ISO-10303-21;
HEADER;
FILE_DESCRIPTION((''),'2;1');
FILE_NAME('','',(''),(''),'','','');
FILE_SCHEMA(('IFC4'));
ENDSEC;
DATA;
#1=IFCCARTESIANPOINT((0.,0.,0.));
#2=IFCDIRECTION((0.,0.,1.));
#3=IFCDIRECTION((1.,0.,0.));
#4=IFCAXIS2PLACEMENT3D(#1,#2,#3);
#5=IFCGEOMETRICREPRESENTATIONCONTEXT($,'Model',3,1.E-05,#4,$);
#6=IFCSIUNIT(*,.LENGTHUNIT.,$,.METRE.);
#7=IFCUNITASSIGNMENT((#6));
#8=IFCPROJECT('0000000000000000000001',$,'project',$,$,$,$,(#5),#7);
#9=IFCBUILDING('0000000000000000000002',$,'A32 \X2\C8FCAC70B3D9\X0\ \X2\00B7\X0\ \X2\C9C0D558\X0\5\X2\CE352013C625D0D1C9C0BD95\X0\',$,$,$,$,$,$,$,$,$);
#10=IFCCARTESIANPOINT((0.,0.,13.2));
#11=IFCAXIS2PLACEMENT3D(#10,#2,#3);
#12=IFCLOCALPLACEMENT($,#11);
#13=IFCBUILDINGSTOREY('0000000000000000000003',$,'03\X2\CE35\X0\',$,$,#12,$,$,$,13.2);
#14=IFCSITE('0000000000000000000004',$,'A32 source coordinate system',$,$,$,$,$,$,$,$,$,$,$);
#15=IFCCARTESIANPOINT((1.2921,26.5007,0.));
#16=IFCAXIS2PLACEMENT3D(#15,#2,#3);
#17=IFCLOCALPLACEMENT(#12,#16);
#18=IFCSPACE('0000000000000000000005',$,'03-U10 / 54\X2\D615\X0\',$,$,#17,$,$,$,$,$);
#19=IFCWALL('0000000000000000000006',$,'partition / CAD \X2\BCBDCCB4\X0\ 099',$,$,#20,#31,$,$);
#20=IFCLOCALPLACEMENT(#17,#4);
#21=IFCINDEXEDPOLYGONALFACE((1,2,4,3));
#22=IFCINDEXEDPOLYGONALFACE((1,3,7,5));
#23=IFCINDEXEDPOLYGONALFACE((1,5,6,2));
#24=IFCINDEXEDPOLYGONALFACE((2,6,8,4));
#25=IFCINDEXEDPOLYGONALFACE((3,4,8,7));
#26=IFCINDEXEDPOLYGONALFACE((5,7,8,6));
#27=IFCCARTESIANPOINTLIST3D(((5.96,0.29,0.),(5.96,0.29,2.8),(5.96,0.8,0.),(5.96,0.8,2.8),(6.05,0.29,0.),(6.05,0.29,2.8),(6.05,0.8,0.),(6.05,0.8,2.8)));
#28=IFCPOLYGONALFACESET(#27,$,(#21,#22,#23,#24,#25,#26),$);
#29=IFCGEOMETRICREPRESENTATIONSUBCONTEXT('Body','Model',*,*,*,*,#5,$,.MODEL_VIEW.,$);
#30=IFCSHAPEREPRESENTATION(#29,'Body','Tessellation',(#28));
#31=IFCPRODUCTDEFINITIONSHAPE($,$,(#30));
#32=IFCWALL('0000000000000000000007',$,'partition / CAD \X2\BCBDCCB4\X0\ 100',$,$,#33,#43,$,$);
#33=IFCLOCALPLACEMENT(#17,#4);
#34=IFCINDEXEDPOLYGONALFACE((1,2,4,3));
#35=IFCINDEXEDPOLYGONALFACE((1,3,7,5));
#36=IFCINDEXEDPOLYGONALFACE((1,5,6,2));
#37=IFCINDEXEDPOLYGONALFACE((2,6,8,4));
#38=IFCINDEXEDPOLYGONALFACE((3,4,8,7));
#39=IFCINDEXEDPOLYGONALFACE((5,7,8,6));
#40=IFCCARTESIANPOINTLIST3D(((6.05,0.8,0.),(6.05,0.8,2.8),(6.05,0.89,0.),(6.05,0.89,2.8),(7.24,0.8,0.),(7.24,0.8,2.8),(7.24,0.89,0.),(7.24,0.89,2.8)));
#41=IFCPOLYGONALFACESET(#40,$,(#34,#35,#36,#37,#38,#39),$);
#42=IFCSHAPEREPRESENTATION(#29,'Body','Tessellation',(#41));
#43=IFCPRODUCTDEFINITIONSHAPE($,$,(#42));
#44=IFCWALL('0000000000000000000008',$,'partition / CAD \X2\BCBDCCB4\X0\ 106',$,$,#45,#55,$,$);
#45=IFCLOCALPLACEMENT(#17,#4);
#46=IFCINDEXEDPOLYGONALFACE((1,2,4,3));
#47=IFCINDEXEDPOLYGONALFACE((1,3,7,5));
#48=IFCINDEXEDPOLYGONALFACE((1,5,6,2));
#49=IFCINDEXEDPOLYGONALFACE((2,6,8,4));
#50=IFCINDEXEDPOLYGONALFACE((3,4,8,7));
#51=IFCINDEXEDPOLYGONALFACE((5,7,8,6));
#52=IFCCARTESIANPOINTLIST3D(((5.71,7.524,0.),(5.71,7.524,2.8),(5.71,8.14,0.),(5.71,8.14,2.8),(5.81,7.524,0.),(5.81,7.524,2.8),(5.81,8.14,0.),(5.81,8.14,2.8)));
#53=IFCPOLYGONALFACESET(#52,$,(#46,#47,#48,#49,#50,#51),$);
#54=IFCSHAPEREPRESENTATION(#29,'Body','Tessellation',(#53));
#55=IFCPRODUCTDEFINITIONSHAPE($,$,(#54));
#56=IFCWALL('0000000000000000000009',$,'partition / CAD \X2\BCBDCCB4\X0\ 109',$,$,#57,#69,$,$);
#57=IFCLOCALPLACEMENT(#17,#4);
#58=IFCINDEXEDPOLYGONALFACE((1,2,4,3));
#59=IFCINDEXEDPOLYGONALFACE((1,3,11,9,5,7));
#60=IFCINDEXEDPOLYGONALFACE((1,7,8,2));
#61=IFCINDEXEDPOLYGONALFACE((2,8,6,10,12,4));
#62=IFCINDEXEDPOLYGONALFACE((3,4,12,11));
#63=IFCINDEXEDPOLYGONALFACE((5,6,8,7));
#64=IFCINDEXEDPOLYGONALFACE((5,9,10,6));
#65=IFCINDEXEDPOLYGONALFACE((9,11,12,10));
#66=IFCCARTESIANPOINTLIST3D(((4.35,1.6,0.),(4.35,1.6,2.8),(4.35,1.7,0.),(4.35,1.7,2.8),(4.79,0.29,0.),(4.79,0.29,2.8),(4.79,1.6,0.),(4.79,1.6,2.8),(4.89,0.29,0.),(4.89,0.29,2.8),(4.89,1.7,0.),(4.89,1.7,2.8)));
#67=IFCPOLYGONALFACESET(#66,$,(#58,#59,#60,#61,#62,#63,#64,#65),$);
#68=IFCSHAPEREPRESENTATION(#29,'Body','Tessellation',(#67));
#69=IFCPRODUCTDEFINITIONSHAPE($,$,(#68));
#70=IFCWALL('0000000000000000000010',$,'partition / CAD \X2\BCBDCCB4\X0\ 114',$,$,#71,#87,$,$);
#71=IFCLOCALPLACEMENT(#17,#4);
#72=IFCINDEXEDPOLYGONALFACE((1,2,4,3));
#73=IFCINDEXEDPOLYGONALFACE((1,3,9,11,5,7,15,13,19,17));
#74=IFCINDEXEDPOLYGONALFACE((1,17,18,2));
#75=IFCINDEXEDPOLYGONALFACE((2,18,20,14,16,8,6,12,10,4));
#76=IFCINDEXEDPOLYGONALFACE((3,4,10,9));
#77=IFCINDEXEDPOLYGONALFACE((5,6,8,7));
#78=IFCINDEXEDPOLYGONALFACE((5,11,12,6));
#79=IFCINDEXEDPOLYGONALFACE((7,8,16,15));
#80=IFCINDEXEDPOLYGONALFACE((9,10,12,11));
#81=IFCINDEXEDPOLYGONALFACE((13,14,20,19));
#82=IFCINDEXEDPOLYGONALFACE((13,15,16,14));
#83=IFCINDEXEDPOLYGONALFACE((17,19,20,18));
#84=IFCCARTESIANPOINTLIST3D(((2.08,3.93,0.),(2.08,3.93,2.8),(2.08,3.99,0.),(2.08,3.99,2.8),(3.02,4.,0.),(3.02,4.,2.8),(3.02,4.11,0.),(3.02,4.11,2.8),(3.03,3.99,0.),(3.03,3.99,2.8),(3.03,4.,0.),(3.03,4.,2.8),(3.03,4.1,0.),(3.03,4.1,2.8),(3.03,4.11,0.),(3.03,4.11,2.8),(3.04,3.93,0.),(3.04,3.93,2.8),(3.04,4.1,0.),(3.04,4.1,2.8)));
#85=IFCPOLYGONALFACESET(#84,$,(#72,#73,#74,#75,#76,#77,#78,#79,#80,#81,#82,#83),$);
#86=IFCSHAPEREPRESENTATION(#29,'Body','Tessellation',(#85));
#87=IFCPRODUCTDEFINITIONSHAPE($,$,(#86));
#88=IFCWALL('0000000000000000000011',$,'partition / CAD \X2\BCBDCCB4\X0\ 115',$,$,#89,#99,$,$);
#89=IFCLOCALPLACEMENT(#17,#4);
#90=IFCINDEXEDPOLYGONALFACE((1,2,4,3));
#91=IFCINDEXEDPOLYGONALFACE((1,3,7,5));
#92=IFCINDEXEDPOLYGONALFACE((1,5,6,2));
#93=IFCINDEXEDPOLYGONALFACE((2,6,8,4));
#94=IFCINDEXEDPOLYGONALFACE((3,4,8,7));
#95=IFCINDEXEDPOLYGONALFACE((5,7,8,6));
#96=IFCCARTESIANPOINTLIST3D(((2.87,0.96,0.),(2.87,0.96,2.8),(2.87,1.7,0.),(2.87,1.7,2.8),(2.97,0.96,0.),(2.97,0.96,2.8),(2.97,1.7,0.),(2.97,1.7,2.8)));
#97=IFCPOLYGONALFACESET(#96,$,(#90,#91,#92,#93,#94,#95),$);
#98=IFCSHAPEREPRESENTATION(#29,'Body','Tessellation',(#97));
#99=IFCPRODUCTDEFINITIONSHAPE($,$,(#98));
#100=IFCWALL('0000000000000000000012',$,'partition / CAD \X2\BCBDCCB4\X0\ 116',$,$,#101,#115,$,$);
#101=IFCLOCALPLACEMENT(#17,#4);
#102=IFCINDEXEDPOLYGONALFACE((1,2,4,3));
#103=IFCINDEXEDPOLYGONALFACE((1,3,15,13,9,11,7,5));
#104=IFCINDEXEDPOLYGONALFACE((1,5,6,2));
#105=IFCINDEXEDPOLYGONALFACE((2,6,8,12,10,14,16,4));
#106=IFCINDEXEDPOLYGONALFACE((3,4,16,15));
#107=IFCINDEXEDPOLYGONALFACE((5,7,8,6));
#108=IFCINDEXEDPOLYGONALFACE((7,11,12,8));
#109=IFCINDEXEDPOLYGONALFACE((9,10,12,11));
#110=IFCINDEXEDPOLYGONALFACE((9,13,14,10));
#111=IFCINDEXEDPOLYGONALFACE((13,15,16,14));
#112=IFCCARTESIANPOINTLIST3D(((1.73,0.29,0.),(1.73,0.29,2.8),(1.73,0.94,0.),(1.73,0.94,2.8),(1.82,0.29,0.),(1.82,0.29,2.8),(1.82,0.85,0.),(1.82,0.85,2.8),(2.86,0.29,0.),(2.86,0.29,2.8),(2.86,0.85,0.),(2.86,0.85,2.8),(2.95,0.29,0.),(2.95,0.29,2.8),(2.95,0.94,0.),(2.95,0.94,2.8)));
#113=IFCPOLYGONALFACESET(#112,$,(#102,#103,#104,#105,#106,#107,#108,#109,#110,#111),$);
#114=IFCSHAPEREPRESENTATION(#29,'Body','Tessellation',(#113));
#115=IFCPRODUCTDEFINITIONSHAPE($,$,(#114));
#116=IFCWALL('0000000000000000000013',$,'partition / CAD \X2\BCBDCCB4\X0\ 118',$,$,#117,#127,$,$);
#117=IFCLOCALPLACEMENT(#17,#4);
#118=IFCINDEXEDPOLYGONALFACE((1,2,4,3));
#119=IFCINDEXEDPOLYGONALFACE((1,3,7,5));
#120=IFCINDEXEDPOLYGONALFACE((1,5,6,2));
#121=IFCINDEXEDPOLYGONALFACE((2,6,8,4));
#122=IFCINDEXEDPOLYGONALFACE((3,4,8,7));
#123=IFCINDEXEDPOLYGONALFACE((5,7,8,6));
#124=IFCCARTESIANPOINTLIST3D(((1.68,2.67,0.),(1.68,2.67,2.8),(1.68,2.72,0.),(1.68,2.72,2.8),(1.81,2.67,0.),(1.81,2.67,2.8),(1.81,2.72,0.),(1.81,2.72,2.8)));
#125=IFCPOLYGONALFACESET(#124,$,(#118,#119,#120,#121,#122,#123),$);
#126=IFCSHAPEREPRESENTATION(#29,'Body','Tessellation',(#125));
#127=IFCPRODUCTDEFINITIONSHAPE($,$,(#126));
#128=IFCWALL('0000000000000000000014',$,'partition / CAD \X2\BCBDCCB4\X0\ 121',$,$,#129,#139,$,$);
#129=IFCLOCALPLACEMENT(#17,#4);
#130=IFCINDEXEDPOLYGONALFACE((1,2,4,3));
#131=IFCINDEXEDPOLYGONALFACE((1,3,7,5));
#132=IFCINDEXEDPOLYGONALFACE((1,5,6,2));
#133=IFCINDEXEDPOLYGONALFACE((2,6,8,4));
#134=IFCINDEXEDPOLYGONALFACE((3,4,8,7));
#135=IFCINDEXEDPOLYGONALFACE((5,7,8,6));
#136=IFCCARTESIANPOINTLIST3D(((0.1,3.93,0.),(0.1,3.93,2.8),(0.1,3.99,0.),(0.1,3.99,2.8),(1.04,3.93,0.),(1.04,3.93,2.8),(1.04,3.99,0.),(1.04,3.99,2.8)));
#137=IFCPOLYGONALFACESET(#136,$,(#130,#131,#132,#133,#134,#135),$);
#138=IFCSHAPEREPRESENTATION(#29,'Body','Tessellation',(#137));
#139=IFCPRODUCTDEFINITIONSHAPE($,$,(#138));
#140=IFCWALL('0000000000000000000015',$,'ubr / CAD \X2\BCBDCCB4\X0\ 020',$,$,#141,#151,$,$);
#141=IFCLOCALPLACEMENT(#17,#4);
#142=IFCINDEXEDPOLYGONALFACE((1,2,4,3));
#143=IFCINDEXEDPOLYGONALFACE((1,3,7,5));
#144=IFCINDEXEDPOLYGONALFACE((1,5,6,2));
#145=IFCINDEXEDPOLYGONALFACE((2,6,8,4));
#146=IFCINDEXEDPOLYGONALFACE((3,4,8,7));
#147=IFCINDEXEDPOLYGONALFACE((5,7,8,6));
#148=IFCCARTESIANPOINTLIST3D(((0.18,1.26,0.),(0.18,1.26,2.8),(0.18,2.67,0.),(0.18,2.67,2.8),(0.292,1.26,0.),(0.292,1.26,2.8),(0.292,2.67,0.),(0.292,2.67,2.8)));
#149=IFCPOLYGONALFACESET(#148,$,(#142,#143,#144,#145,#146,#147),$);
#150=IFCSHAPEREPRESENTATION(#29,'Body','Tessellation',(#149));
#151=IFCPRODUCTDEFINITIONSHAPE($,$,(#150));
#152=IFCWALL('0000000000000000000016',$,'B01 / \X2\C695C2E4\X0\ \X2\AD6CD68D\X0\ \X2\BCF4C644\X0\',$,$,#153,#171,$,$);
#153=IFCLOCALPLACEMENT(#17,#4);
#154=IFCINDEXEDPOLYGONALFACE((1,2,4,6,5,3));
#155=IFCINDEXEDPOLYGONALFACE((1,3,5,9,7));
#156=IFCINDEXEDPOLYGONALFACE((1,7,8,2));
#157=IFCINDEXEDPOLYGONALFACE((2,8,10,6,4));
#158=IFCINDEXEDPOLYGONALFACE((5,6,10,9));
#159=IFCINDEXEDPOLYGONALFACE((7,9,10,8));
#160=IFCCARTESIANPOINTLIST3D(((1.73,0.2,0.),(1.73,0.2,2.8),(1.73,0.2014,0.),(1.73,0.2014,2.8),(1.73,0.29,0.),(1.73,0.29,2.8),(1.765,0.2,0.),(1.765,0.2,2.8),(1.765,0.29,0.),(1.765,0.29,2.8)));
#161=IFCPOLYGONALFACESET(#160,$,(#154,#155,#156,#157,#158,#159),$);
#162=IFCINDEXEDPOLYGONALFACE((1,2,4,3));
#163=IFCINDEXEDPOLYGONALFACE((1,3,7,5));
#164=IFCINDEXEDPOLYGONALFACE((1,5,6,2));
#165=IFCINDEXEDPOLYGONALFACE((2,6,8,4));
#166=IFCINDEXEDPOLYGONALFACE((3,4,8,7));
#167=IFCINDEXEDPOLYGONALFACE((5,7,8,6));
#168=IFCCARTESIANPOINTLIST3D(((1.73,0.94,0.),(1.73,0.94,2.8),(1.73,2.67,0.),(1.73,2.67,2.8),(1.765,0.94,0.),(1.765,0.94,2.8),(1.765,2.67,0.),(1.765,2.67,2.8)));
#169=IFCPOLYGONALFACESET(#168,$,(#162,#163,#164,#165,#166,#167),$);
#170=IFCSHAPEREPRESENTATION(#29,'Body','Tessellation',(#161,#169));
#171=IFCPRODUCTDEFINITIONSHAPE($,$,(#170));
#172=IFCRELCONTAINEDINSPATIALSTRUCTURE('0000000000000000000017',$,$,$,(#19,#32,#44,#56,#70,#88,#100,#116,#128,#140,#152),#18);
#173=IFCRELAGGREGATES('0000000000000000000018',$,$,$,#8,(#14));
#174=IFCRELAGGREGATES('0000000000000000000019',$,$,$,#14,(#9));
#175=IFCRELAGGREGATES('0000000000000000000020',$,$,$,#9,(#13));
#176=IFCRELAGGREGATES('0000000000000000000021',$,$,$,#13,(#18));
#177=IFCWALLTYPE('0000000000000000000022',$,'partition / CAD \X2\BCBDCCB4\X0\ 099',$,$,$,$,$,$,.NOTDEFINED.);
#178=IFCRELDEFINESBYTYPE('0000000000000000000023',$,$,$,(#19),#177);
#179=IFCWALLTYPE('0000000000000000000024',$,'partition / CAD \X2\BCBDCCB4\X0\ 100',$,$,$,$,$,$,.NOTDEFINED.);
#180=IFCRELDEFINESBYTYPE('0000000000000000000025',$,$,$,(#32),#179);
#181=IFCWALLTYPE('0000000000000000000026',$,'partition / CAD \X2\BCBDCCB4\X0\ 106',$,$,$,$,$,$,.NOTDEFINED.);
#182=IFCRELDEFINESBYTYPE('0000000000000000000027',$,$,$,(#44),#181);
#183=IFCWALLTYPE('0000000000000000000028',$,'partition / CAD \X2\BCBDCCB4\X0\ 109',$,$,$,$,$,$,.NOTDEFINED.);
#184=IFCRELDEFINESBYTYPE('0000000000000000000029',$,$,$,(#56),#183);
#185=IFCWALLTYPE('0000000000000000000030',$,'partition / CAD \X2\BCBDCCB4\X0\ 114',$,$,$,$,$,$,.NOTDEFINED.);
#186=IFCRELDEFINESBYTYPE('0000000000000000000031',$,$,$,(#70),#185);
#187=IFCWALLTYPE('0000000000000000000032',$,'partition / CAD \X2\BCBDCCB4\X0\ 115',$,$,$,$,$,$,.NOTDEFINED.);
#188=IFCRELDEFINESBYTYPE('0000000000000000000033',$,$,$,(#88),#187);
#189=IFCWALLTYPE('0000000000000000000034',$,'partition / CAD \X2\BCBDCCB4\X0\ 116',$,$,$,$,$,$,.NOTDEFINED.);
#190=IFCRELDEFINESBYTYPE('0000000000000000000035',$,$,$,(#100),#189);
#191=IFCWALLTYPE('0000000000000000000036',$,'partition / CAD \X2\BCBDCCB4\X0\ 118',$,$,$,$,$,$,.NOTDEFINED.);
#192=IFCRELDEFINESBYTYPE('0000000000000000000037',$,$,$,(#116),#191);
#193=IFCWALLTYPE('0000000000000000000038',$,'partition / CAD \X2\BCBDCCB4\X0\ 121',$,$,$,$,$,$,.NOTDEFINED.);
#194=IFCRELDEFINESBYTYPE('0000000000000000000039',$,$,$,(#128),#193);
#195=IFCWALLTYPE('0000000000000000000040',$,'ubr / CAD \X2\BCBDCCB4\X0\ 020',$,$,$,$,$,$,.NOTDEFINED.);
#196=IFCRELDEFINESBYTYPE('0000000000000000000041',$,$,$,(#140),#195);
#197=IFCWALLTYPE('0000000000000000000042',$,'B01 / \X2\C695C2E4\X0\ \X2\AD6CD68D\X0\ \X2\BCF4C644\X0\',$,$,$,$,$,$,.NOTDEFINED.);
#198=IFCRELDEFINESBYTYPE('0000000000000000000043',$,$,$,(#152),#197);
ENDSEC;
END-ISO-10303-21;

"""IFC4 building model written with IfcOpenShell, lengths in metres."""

from ifc_helpers import new_model, si_unit, frame, origin, origin_with_axes, place, context, subcontext, project, spatial, polyline, outline, extrude, source, transform, mapped, type_object, type_shapes, element, save


model = new_model("IFC4")

# Units and contexts
model_context = context("Model", 3, precision=1e-05, world=origin_with_axes())
body_context = subcontext(model_context, "Body", "Model", "MODEL_VIEW")
ifc_project = project(units=[si_unit("LENGTHUNIT", "METRE")], contexts=[model_context])

# Site, building, storey, space
storey_placement = place(None, frame((0.0, 0.0, 13.2), z_axis=(0.0, 0.0, 1.0), x_axis=(1.0, 0.0, 0.0)))
space_placement = place(storey_placement, frame((1.2921, 26.5007, 0.0), z_axis=(0.0, 0.0, 1.0), x_axis=(1.0, 0.0, 0.0)))
site = spatial("IfcSite", under=ifc_project, Name="A32 source coordinate system")
building = spatial("IfcBuilding", under=site, Name="A32 주거동 · 지하5층–옥탑지붕")
storey = spatial("IfcBuildingStorey", under=building, at=storey_placement, Name="03층", Elevation=13.2)
space = spatial("IfcSpace", under=storey, at=space_placement, Name="03-U10 / 54형")

# Walls
wall_type_1 = type_object("IfcWallType", Name="partition / CAD 벽체 099", PredefinedType="NOTDEFINED")
shared_shape_1 = source(origin(), body_context, "Body", "SweptSolid", [
    extrude(outline(polyline([(6.05, 0.8), (6.05, 0.29), (5.96, 0.29), (5.96, 0.8), (6.05, 0.8)])), origin(), (0.0, 0.0, 1.0), 2.8),
])
type_shapes(wall_type_1, [shared_shape_1])
wall_1_placement = place(space_placement, origin_with_axes())
element("IfcWall", 1, at=wall_1_placement, inside=space, type_object=wall_type_1, Name="partition / CAD 벽체 099", context=body_context, shape_type="MappedRepresentation", body=[
    mapped(shared_shape_1, transform((0.0, 0.0, 0.0), scale=1.0)),
])
wall_type_2 = type_object("IfcWallType", Name="partition / CAD 벽체 100", PredefinedType="NOTDEFINED")
shared_shape_2 = source(origin(), body_context, "Body", "SweptSolid", [
    extrude(outline(polyline([(7.24, 0.8), (6.05, 0.8), (6.05, 0.89), (7.24, 0.89), (7.24, 0.8)])), origin(), (0.0, 0.0, 1.0), 2.8),
])
type_shapes(wall_type_2, [shared_shape_2])
wall_2_placement = place(space_placement, origin_with_axes())
element("IfcWall", 2, at=wall_2_placement, inside=space, type_object=wall_type_2, Name="partition / CAD 벽체 100", context=body_context, shape_type="MappedRepresentation", body=[
    mapped(shared_shape_2, transform((0.0, 0.0, 0.0), scale=1.0)),
])
wall_type_3 = type_object("IfcWallType", Name="partition / CAD 벽체 106", PredefinedType="NOTDEFINED")
shared_shape_3 = source(origin(), body_context, "Body", "SweptSolid", [
    extrude(outline(polyline([(5.71, 8.14), (5.81, 8.14), (5.81, 7.524), (5.71, 7.524), (5.71, 8.14)])), origin(), (0.0, 0.0, 1.0), 2.8),
])
type_shapes(wall_type_3, [shared_shape_3])
wall_3_placement = place(space_placement, origin_with_axes())
element("IfcWall", 3, at=wall_3_placement, inside=space, type_object=wall_type_3, Name="partition / CAD 벽체 106", context=body_context, shape_type="MappedRepresentation", body=[
    mapped(shared_shape_3, transform((0.0, 0.0, 0.0), scale=1.0)),
])
wall_type_4 = type_object("IfcWallType", Name="partition / CAD 벽체 109", PredefinedType="NOTDEFINED")
shared_shape_4 = source(origin(), body_context, "Body", "SweptSolid", [
    extrude(outline(polyline([(4.79, 1.6), (4.35, 1.6), (4.35, 1.7), (4.89, 1.7), (4.89, 0.29), (4.79, 0.29), (4.79, 1.6)])), origin(), (0.0, 0.0, 1.0), 2.8),
])
type_shapes(wall_type_4, [shared_shape_4])
wall_4_placement = place(space_placement, origin_with_axes())
element("IfcWall", 4, at=wall_4_placement, inside=space, type_object=wall_type_4, Name="partition / CAD 벽체 109", context=body_context, shape_type="MappedRepresentation", body=[
    mapped(shared_shape_4, transform((0.0, 0.0, 0.0), scale=1.0)),
])
wall_type_5 = type_object("IfcWallType", Name="partition / CAD 벽체 114", PredefinedType="NOTDEFINED")
shared_shape_5 = source(origin(), body_context, "Body", "SweptSolid", [
    extrude(outline(polyline([(2.08, 3.99), (3.03, 3.99), (3.03, 4.0), (3.02, 4.0), (3.02, 4.11), (3.03, 4.11), (3.03, 4.1), (3.04, 4.1), (3.04, 3.93), (2.08, 3.93), (2.08, 3.99)])), origin(), (0.0, 0.0, 1.0), 2.8),
])
type_shapes(wall_type_5, [shared_shape_5])
wall_5_placement = place(space_placement, origin_with_axes())
element("IfcWall", 5, at=wall_5_placement, inside=space, type_object=wall_type_5, Name="partition / CAD 벽체 114", context=body_context, shape_type="MappedRepresentation", body=[
    mapped(shared_shape_5, transform((0.0, 0.0, 0.0), scale=1.0)),
])
wall_type_6 = type_object("IfcWallType", Name="partition / CAD 벽체 115", PredefinedType="NOTDEFINED")
shared_shape_6 = source(origin(), body_context, "Body", "SweptSolid", [
    extrude(outline(polyline([(2.87, 1.7), (2.97, 1.7), (2.97, 0.96), (2.87, 0.96), (2.87, 1.7)])), origin(), (0.0, 0.0, 1.0), 2.8),
])
type_shapes(wall_type_6, [shared_shape_6])
wall_6_placement = place(space_placement, origin_with_axes())
element("IfcWall", 6, at=wall_6_placement, inside=space, type_object=wall_type_6, Name="partition / CAD 벽체 115", context=body_context, shape_type="MappedRepresentation", body=[
    mapped(shared_shape_6, transform((0.0, 0.0, 0.0), scale=1.0)),
])
wall_type_7 = type_object("IfcWallType", Name="partition / CAD 벽체 116", PredefinedType="NOTDEFINED")
shared_shape_7 = source(origin(), body_context, "Body", "SweptSolid", [
    extrude(outline(polyline([(2.95, 0.29), (2.86, 0.29), (2.86, 0.85), (1.82, 0.85), (1.82, 0.29), (1.73, 0.29), (1.73, 0.94), (2.95, 0.94), (2.95, 0.29)])), origin(), (0.0, 0.0, 1.0), 2.8),
])
type_shapes(wall_type_7, [shared_shape_7])
wall_7_placement = place(space_placement, origin_with_axes())
element("IfcWall", 7, at=wall_7_placement, inside=space, type_object=wall_type_7, Name="partition / CAD 벽체 116", context=body_context, shape_type="MappedRepresentation", body=[
    mapped(shared_shape_7, transform((0.0, 0.0, 0.0), scale=1.0)),
])
wall_type_8 = type_object("IfcWallType", Name="partition / CAD 벽체 118", PredefinedType="NOTDEFINED")
shared_shape_8 = source(origin(), body_context, "Body", "SweptSolid", [
    extrude(outline(polyline([(1.81, 2.67), (1.68, 2.67), (1.68, 2.72), (1.81, 2.72), (1.81, 2.67)])), origin(), (0.0, 0.0, 1.0), 2.8),
])
type_shapes(wall_type_8, [shared_shape_8])
wall_8_placement = place(space_placement, origin_with_axes())
element("IfcWall", 8, at=wall_8_placement, inside=space, type_object=wall_type_8, Name="partition / CAD 벽체 118", context=body_context, shape_type="MappedRepresentation", body=[
    mapped(shared_shape_8, transform((0.0, 0.0, 0.0), scale=1.0)),
])
wall_type_9 = type_object("IfcWallType", Name="partition / CAD 벽체 121", PredefinedType="NOTDEFINED")
shared_shape_9 = source(origin(), body_context, "Body", "SweptSolid", [
    extrude(outline(polyline([(0.1, 3.99), (1.04, 3.99), (1.04, 3.93), (0.1, 3.93), (0.1, 3.99)])), origin(), (0.0, 0.0, 1.0), 2.8),
])
type_shapes(wall_type_9, [shared_shape_9])
wall_9_placement = place(space_placement, origin_with_axes())
element("IfcWall", 9, at=wall_9_placement, inside=space, type_object=wall_type_9, Name="partition / CAD 벽체 121", context=body_context, shape_type="MappedRepresentation", body=[
    mapped(shared_shape_9, transform((0.0, 0.0, 0.0), scale=1.0)),
])
wall_type_10 = type_object("IfcWallType", Name="ubr / CAD 벽체 020", PredefinedType="NOTDEFINED")
shared_shape_10 = source(origin(), body_context, "Body", "SweptSolid", [
    extrude(outline(polyline([(0.18, 1.26), (0.18, 2.67), (0.292, 2.67), (0.292, 1.26), (0.18, 1.26)])), origin(), (0.0, 0.0, 1.0), 2.8),
])
type_shapes(wall_type_10, [shared_shape_10])
wall_10_placement = place(space_placement, origin_with_axes())
element("IfcWall", 10, at=wall_10_placement, inside=space, type_object=wall_type_10, Name="ubr / CAD 벽체 020", context=body_context, shape_type="MappedRepresentation", body=[
    mapped(shared_shape_10, transform((0.0, 0.0, 0.0), scale=1.0)),
])
wall_type_11 = type_object("IfcWallType", Name="B01 / 욕실 구획 보완", PredefinedType="NOTDEFINED")
shared_shape_11 = source(origin(), body_context, "Body", "SweptSolid", [
    extrude(outline(polyline([(1.765, 0.2), (1.73, 0.2), (1.73, 0.2014), (1.73, 0.29), (1.765, 0.29), (1.765, 0.2)])), origin(), (0.0, 0.0, 1.0), 2.8),
    extrude(outline(polyline([(1.765, 2.67), (1.765, 0.94), (1.73, 0.94), (1.73, 2.67), (1.765, 2.67)])), origin(), (0.0, 0.0, 1.0), 2.8),
])
type_shapes(wall_type_11, [shared_shape_11])
wall_11_placement = place(space_placement, origin_with_axes())
element("IfcWall", 11, at=wall_11_placement, inside=space, type_object=wall_type_11, Name="B01 / 욕실 구획 보완", context=body_context, shape_type="MappedRepresentation", body=[
    mapped(shared_shape_11, transform((0.0, 0.0, 0.0), scale=1.0)),
])

save(model, "model.ifc")
